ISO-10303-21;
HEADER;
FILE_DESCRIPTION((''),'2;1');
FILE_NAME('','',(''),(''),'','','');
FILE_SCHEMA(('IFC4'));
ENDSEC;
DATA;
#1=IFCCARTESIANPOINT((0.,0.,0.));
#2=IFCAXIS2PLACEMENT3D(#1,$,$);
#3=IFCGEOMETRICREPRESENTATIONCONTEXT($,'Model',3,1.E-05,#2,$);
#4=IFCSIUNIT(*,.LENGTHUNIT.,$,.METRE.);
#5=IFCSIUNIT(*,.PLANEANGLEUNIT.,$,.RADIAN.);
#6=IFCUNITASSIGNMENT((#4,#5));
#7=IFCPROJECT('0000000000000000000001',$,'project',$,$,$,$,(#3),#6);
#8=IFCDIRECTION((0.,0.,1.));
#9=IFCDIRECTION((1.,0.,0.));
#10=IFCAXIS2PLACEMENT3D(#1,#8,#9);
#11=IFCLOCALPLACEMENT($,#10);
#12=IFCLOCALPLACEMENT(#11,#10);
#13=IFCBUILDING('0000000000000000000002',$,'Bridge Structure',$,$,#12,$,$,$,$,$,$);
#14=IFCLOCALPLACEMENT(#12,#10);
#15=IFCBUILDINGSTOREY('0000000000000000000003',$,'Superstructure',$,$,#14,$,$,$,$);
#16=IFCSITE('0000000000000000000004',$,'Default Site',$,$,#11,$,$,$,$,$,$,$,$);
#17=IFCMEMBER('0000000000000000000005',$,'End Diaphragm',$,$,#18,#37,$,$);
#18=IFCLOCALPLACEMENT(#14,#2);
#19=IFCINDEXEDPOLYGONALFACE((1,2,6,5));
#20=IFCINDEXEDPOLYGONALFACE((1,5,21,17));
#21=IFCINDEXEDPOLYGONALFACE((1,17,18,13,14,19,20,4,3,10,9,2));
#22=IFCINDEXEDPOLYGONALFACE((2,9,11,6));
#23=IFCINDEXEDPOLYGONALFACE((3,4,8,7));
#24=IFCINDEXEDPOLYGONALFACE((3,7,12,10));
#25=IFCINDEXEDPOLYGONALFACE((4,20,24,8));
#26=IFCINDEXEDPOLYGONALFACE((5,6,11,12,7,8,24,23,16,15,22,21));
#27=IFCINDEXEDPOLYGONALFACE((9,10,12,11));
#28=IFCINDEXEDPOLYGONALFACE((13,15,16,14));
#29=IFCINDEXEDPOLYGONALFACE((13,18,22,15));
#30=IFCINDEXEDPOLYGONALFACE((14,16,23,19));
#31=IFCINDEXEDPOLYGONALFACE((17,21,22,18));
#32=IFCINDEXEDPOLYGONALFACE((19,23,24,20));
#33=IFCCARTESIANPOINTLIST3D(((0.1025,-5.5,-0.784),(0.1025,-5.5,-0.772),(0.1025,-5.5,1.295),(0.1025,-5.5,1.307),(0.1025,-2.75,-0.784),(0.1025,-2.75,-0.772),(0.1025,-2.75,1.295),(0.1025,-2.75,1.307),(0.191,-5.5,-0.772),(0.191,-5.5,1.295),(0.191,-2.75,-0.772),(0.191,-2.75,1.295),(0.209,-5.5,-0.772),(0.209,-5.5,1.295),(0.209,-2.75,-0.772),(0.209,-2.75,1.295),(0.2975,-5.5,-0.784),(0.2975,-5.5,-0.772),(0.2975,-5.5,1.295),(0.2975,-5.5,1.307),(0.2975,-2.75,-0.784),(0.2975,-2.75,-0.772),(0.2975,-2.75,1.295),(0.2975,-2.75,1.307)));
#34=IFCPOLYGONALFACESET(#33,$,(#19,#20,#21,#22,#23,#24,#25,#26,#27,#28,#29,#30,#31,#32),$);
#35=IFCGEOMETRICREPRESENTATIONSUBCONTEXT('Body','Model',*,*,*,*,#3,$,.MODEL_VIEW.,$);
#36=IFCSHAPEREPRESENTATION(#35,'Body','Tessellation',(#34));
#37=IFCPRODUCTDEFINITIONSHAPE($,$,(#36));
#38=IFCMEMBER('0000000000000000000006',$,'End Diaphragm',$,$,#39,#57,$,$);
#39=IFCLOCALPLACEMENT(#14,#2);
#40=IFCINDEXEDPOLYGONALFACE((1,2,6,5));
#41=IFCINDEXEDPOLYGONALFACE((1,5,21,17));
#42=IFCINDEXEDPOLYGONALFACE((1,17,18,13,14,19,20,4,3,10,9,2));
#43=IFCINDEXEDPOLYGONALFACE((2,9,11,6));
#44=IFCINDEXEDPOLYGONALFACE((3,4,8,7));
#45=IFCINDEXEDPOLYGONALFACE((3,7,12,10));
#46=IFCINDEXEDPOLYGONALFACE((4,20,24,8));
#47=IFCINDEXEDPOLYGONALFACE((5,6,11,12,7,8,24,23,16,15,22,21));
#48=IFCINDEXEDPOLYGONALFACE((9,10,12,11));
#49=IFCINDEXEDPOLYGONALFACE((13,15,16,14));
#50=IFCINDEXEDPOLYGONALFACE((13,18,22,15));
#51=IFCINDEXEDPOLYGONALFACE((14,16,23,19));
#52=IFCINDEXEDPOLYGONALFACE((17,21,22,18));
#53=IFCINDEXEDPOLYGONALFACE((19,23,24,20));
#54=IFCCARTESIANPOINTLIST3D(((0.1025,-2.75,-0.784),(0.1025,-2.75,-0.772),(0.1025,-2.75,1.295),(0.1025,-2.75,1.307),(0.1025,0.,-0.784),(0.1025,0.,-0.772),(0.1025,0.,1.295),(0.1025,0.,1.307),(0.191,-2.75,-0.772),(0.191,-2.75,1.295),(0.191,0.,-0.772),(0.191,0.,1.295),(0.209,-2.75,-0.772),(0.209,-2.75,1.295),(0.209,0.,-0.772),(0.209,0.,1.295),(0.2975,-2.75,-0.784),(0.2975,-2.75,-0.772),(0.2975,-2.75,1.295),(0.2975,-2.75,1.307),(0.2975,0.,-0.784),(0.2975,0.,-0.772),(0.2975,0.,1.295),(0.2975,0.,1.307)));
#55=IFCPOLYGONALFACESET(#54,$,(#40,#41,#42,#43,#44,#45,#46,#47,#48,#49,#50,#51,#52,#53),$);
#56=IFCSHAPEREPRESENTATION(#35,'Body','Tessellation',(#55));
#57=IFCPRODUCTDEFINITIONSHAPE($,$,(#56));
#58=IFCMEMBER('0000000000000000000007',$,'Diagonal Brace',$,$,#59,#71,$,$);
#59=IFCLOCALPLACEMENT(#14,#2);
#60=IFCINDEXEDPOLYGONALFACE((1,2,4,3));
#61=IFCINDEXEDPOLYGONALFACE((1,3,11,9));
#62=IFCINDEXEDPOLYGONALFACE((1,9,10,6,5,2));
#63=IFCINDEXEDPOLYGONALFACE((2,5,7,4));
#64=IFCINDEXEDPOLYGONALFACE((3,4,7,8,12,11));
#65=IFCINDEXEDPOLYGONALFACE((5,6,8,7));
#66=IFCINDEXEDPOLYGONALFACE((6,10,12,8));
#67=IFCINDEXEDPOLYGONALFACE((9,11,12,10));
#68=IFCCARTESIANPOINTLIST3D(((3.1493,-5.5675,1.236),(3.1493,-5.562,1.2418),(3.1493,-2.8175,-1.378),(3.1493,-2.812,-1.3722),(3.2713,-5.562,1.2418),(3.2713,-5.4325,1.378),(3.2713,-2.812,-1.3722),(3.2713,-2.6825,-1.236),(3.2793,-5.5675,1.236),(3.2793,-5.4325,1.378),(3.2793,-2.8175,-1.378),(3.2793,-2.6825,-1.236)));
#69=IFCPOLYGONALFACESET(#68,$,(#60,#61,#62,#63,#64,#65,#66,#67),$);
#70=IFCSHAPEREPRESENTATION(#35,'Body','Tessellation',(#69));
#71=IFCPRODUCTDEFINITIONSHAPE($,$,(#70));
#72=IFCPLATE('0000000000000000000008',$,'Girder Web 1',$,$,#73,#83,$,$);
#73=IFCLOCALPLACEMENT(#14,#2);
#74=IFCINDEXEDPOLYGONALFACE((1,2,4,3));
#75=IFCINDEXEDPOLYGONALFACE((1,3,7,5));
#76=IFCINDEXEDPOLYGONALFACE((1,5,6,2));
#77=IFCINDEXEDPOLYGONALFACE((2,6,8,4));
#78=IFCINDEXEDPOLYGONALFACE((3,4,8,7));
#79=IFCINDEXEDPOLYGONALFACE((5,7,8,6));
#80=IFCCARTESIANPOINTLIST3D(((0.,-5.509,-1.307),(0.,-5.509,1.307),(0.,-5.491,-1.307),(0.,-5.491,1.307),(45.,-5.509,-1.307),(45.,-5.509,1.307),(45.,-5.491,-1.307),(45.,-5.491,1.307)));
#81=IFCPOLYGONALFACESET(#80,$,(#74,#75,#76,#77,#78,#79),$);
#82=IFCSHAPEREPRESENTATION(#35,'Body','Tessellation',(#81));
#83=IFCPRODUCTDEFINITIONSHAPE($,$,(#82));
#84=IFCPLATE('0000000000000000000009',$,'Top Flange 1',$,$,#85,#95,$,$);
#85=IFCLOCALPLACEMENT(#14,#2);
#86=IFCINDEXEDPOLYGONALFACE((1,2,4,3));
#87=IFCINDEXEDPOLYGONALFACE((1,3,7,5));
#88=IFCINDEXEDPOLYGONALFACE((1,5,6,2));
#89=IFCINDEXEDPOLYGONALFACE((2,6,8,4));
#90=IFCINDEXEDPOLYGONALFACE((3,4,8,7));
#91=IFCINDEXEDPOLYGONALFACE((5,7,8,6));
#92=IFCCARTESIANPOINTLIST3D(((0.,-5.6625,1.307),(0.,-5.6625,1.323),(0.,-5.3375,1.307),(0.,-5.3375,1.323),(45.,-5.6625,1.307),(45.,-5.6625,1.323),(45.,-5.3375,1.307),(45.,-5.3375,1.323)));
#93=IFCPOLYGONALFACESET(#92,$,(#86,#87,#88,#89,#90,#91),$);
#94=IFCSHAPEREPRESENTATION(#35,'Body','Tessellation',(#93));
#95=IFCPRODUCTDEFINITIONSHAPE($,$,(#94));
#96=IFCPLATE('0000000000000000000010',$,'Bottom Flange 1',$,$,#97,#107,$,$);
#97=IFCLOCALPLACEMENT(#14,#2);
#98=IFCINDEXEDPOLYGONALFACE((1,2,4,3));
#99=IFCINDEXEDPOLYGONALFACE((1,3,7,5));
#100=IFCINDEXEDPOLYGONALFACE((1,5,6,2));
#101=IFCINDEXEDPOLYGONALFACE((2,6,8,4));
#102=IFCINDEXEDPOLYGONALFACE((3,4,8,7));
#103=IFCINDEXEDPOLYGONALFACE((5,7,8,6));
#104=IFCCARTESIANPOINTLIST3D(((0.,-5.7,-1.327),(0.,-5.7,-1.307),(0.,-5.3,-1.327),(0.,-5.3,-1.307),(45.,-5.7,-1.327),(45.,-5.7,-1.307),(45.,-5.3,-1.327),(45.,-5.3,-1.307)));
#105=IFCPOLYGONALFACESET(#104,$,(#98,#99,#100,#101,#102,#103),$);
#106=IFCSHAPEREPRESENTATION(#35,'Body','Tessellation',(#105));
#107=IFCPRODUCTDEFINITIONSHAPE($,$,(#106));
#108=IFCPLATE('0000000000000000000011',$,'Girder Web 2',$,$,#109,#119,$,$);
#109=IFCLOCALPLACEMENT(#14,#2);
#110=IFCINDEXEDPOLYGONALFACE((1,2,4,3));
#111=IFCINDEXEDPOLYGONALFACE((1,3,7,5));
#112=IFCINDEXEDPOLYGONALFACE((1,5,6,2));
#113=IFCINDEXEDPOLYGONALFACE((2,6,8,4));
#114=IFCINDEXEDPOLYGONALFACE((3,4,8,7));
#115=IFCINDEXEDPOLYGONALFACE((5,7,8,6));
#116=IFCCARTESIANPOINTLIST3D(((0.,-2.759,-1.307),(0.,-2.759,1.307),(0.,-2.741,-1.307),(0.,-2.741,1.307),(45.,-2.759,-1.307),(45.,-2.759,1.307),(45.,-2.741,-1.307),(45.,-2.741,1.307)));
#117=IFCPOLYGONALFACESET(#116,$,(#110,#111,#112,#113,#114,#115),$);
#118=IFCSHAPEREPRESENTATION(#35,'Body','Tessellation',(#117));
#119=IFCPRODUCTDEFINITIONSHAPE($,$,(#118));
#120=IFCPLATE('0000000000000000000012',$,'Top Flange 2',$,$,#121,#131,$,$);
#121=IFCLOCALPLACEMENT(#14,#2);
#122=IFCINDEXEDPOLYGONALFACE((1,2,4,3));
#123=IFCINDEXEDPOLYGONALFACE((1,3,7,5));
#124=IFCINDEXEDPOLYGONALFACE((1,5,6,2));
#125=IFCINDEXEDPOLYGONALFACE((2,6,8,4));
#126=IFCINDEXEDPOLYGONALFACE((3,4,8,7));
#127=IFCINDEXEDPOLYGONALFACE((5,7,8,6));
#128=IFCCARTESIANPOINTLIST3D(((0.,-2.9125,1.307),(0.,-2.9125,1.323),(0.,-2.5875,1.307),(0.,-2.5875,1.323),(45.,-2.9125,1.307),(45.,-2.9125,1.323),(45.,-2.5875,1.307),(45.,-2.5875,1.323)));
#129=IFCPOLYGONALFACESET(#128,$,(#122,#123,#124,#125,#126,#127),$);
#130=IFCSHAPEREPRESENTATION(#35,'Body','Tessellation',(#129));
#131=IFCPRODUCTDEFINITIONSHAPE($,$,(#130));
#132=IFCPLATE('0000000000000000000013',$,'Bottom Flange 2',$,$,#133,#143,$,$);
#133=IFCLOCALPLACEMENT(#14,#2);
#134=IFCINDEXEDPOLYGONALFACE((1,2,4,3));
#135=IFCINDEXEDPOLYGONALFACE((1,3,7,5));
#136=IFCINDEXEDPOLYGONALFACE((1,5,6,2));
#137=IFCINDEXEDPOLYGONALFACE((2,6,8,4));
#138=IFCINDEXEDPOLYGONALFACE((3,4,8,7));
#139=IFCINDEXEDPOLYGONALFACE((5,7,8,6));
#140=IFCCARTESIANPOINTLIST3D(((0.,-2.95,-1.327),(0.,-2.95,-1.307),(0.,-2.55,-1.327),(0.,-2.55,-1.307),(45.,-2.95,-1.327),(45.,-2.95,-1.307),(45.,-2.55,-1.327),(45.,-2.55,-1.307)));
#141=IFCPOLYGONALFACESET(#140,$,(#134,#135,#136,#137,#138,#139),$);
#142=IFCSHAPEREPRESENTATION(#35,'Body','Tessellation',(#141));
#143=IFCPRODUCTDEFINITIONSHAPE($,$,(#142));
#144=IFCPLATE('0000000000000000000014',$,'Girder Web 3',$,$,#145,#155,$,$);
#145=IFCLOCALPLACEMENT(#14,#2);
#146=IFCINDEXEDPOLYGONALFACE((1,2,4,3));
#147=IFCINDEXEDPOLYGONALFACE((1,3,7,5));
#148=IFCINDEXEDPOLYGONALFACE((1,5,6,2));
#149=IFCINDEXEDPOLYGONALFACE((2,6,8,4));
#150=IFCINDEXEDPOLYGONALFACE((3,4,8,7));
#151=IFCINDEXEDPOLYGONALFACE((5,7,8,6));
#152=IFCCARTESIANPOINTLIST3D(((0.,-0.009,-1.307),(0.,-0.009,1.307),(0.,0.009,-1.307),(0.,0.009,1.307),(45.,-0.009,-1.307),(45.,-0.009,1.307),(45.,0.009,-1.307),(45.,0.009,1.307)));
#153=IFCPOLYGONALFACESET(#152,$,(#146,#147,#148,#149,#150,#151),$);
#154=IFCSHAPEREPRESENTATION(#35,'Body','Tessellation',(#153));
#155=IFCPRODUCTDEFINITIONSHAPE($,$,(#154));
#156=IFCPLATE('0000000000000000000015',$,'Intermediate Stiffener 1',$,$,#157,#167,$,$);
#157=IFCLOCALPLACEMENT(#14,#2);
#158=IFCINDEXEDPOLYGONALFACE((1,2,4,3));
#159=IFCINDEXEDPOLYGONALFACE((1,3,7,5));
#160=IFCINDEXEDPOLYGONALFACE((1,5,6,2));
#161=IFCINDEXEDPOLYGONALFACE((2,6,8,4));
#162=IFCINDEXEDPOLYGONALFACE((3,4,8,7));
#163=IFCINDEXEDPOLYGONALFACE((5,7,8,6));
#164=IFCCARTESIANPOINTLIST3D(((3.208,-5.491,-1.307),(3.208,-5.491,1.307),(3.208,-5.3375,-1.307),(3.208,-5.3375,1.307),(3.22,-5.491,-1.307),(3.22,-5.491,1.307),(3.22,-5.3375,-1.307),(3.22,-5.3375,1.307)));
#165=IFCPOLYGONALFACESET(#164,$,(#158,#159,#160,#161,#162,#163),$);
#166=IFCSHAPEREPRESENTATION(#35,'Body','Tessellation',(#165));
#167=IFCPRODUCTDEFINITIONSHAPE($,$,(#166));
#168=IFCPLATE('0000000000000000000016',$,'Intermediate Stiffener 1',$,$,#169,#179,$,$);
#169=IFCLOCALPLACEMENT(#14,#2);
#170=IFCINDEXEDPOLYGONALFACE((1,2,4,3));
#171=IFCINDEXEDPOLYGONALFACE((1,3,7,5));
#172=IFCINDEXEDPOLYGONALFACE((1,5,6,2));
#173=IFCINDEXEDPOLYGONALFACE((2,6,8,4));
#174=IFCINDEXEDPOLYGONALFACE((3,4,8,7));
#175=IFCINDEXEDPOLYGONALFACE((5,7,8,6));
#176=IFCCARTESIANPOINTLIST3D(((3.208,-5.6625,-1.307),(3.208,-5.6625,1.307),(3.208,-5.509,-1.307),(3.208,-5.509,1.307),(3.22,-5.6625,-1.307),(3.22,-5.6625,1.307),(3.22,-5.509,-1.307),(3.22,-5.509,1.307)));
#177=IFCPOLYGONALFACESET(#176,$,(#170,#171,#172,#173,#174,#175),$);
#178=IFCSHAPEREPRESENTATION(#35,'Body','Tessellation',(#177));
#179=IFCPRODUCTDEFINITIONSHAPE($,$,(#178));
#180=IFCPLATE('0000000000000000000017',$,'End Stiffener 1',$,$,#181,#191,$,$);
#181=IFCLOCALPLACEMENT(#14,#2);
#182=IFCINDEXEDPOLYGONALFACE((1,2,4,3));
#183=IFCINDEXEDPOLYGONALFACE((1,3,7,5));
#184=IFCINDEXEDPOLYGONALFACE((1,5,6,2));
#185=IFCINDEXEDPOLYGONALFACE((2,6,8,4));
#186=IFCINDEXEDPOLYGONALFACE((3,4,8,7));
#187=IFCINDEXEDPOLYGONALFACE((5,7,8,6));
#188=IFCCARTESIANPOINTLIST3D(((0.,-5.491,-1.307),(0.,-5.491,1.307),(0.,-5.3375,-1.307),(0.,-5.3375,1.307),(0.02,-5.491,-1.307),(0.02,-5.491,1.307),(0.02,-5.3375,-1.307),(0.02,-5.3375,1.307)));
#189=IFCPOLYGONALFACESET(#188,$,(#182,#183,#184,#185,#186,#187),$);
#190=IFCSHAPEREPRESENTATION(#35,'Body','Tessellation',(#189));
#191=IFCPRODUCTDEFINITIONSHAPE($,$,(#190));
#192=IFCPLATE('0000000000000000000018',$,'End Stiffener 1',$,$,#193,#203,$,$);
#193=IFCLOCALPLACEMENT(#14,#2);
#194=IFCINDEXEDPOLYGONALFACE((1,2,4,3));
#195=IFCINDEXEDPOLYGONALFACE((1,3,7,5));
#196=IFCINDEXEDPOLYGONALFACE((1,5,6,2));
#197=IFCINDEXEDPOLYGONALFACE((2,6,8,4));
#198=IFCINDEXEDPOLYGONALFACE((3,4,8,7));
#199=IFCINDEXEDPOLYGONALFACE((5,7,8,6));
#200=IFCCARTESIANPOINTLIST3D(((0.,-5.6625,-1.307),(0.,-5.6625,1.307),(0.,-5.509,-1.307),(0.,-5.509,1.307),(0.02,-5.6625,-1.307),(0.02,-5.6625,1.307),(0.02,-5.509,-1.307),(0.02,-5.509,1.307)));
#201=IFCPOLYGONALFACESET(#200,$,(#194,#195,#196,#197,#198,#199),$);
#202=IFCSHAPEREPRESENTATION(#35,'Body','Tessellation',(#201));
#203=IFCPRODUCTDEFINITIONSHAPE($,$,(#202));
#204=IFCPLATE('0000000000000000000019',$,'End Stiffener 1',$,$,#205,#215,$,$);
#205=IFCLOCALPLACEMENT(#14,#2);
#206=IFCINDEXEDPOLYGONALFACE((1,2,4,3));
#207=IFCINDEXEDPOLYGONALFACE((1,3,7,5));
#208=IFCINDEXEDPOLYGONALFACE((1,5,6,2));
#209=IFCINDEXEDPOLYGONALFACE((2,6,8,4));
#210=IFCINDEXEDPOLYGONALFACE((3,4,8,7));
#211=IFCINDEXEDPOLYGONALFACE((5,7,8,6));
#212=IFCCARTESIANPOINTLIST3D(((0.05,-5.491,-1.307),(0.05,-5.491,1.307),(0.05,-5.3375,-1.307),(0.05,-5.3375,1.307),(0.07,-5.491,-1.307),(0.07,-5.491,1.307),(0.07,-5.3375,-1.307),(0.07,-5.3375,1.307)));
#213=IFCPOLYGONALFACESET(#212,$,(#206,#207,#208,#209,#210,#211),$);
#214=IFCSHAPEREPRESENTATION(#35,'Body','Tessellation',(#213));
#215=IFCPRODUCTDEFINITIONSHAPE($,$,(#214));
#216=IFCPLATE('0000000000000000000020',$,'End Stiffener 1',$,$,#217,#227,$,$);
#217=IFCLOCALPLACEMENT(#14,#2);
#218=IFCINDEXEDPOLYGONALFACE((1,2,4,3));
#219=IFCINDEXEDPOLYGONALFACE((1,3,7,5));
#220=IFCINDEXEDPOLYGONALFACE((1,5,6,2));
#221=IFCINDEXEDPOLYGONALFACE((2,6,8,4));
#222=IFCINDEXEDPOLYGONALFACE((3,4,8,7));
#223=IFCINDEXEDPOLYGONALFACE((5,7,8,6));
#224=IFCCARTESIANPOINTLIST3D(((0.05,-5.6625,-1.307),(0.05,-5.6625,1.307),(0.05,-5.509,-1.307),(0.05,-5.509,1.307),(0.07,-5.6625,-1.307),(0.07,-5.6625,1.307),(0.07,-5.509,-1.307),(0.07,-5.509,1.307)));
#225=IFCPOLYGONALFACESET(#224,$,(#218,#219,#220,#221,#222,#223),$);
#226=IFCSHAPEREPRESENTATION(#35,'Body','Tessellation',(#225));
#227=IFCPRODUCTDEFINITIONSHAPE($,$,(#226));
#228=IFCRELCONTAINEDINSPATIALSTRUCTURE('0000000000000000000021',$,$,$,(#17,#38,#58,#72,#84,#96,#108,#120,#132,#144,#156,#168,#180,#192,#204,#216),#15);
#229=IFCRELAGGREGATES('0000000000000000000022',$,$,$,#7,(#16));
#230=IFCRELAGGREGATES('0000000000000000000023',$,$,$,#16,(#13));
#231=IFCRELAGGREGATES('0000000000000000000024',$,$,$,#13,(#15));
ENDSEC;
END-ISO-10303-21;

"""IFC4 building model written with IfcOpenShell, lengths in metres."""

from ifc_helpers import new_model, si_unit, frame, origin, origin_with_axes, origin_2d_with_axis, place, context, subcontext, project, spatial, rectangle, i_section, l_section, extrude, element, save


model = new_model("IFC4")

# Units and contexts
model_context = context("Model", 3, precision=1e-05, world=origin())
body_context = subcontext(model_context, "Body", "Model", "MODEL_VIEW")
ifc_project = project(units=[si_unit("LENGTHUNIT", "METRE"), si_unit("PLANEANGLEUNIT", "RADIAN")], contexts=[model_context])

# Site, building, storey
site_placement = place(None, origin_with_axes())
site = spatial("IfcSite", under=ifc_project, at=site_placement, Name="Default Site")
building_placement = place(site_placement, origin_with_axes())
building = spatial("IfcBuilding", under=site, at=building_placement, Name="Bridge Structure")
storey_placement = place(building_placement, origin_with_axes())
storey = spatial("IfcBuildingStorey", under=building, at=storey_placement, Name="Superstructure")

# Members
for number, where, z_axis, x_axis, name in (
    (1, (0.2, -5.5, 0.2615), (0.0, 1.0, 0.0), (-1.0, 0.0, 0.0), "End Diaphragm"),
    (2, (0.2, -2.75, 0.2615), (0.0, 1.0, 0.0), (-1.0, 0.0, 0.0), "End Diaphragm"),
):
    element("IfcMember", number, at=place(storey_placement, frame(where, z_axis=z_axis, x_axis=x_axis)), inside=storey, Name=name, context=body_context, shape_type="SweptSolid", body=[
        extrude(i_section(OverallWidth=0.195, OverallDepth=2.091, WebThickness=0.018, FlangeThickness=0.012, at=origin_2d_with_axis()), origin_with_axes(), (0.0, 0.0, 1.0), 2.75),
    ])
member_placement = place(storey_placement, frame((3.2143, -5.5, 1.307), z_axis=(0.0, 0.724802, -0.688957), x_axis=(-1.0, 0.0, 0.0)))
element("IfcMember", 3, at=member_placement, inside=storey, Name="Diagonal Brace", context=body_context, shape_type="SweptSolid", body=[
    extrude(l_section(Depth=0.196, Width=0.13, Thickness=0.008, at=origin_2d_with_axis()), origin_with_axes(), (0.0, 0.0, 1.0), 3.7941),
])

# Plates
plate_1_placement = place(storey_placement, frame((0.0, -5.5, 0.0), z_axis=(1.0, 0.0, 0.0), x_axis=(0.0, 1.0, 0.0)))
element("IfcPlate", 4, at=plate_1_placement, inside=storey, Name="Girder Web 1", context=body_context, shape_type="SweptSolid", body=[
    extrude(rectangle(XDim=0.018, YDim=2.614, at=origin_2d_with_axis()), origin_with_axes(), (0.0, 0.0, 1.0), 45.0),
])
plate_2_placement = place(storey_placement, frame((0.0, -5.5, 1.315), z_axis=(1.0, 0.0, 0.0), x_axis=(0.0, 1.0, 0.0)))
element("IfcPlate", 5, at=plate_2_placement, inside=storey, Name="Top Flange 1", context=body_context, shape_type="SweptSolid", body=[
    extrude(rectangle(XDim=0.325, YDim=0.016, at=origin_2d_with_axis()), origin_with_axes(), (0.0, 0.0, 1.0), 45.0),
])
plate_3_placement = place(storey_placement, frame((0.0, -5.5, -1.317), z_axis=(1.0, 0.0, 0.0), x_axis=(0.0, 1.0, 0.0)))
element("IfcPlate", 6, at=plate_3_placement, inside=storey, Name="Bottom Flange 1", context=body_context, shape_type="SweptSolid", body=[
    extrude(rectangle(XDim=0.4, YDim=0.02, at=origin_2d_with_axis()), origin_with_axes(), (0.0, 0.0, 1.0), 45.0),
])
plate_4_placement = place(storey_placement, frame((0.0, -2.75, 0.0), z_axis=(1.0, 0.0, 0.0), x_axis=(0.0, 1.0, 0.0)))
element("IfcPlate", 7, at=plate_4_placement, inside=storey, Name="Girder Web 2", context=body_context, shape_type="SweptSolid", body=[
    extrude(rectangle(XDim=0.018, YDim=2.614, at=origin_2d_with_axis()), origin_with_axes(), (0.0, 0.0, 1.0), 45.0),
])
plate_5_placement = place(storey_placement, frame((0.0, -2.75, 1.315), z_axis=(1.0, 0.0, 0.0), x_axis=(0.0, 1.0, 0.0)))
element("IfcPlate", 8, at=plate_5_placement, inside=storey, Name="Top Flange 2", context=body_context, shape_type="SweptSolid", body=[
    extrude(rectangle(XDim=0.325, YDim=0.016, at=origin_2d_with_axis()), origin_with_axes(), (0.0, 0.0, 1.0), 45.0),
])
plate_6_placement = place(storey_placement, frame((0.0, -2.75, -1.317), z_axis=(1.0, 0.0, 0.0), x_axis=(0.0, 1.0, 0.0)))
element("IfcPlate", 9, at=plate_6_placement, inside=storey, Name="Bottom Flange 2", context=body_context, shape_type="SweptSolid", body=[
    extrude(rectangle(XDim=0.4, YDim=0.02, at=origin_2d_with_axis()), origin_with_axes(), (0.0, 0.0, 1.0), 45.0),
])
plate_7_placement = place(storey_placement, frame((0.0, 0.0, 0.0), z_axis=(1.0, 0.0, 0.0), x_axis=(0.0, 1.0, 0.0)))
element("IfcPlate", 10, at=plate_7_placement, inside=storey, Name="Girder Web 3", context=body_context, shape_type="SweptSolid", body=[
    extrude(rectangle(XDim=0.018, YDim=2.614, at=origin_2d_with_axis()), origin_with_axes(), (0.0, 0.0, 1.0), 45.0),
])
for number, where, z_axis, x_axis, name in (
    (11, (3.214, -5.4143, -1.307), (0.0, 0.0, 1.0), (1.0, 0.0, 0.0), "Intermediate Stiffener 1"),
    (12, (3.214, -5.5857, -1.307), (0.0, 0.0, 1.0), (1.0, 0.0, 0.0), "Intermediate Stiffener 1"),
):
    element("IfcPlate", number, at=place(storey_placement, frame(where, z_axis=z_axis, x_axis=x_axis)), inside=storey, Name=name, context=body_context, shape_type="SweptSolid", body=[
        extrude(rectangle(XDim=0.012, YDim=0.1535, at=origin_2d_with_axis()), origin_with_axes(), (0.0, 0.0, 1.0), 2.614),
    ])
for number, where, z_axis, x_axis, name in (
    (13, (0.01, -5.4143, -1.307), (0.0, 0.0, 1.0), (1.0, 0.0, 0.0), "End Stiffener 1"),
    (14, (0.01, -5.5857, -1.307), (0.0, 0.0, 1.0), (1.0, 0.0, 0.0), "End Stiffener 1"),
    (15, (0.06, -5.4143, -1.307), (0.0, 0.0, 1.0), (1.0, 0.0, 0.0), "End Stiffener 1"),
    (16, (0.06, -5.5857, -1.307), (0.0, 0.0, 1.0), (1.0, 0.0, 0.0), "End Stiffener 1"),
):
    element("IfcPlate", number, at=place(storey_placement, frame(where, z_axis=z_axis, x_axis=x_axis)), inside=storey, Name=name, context=body_context, shape_type="SweptSolid", body=[
        extrude(rectangle(XDim=0.02, YDim=0.1535, at=origin_2d_with_axis()), origin_with_axes(), (0.0, 0.0, 1.0), 2.614),
    ])

save(model, "model.ifc")
